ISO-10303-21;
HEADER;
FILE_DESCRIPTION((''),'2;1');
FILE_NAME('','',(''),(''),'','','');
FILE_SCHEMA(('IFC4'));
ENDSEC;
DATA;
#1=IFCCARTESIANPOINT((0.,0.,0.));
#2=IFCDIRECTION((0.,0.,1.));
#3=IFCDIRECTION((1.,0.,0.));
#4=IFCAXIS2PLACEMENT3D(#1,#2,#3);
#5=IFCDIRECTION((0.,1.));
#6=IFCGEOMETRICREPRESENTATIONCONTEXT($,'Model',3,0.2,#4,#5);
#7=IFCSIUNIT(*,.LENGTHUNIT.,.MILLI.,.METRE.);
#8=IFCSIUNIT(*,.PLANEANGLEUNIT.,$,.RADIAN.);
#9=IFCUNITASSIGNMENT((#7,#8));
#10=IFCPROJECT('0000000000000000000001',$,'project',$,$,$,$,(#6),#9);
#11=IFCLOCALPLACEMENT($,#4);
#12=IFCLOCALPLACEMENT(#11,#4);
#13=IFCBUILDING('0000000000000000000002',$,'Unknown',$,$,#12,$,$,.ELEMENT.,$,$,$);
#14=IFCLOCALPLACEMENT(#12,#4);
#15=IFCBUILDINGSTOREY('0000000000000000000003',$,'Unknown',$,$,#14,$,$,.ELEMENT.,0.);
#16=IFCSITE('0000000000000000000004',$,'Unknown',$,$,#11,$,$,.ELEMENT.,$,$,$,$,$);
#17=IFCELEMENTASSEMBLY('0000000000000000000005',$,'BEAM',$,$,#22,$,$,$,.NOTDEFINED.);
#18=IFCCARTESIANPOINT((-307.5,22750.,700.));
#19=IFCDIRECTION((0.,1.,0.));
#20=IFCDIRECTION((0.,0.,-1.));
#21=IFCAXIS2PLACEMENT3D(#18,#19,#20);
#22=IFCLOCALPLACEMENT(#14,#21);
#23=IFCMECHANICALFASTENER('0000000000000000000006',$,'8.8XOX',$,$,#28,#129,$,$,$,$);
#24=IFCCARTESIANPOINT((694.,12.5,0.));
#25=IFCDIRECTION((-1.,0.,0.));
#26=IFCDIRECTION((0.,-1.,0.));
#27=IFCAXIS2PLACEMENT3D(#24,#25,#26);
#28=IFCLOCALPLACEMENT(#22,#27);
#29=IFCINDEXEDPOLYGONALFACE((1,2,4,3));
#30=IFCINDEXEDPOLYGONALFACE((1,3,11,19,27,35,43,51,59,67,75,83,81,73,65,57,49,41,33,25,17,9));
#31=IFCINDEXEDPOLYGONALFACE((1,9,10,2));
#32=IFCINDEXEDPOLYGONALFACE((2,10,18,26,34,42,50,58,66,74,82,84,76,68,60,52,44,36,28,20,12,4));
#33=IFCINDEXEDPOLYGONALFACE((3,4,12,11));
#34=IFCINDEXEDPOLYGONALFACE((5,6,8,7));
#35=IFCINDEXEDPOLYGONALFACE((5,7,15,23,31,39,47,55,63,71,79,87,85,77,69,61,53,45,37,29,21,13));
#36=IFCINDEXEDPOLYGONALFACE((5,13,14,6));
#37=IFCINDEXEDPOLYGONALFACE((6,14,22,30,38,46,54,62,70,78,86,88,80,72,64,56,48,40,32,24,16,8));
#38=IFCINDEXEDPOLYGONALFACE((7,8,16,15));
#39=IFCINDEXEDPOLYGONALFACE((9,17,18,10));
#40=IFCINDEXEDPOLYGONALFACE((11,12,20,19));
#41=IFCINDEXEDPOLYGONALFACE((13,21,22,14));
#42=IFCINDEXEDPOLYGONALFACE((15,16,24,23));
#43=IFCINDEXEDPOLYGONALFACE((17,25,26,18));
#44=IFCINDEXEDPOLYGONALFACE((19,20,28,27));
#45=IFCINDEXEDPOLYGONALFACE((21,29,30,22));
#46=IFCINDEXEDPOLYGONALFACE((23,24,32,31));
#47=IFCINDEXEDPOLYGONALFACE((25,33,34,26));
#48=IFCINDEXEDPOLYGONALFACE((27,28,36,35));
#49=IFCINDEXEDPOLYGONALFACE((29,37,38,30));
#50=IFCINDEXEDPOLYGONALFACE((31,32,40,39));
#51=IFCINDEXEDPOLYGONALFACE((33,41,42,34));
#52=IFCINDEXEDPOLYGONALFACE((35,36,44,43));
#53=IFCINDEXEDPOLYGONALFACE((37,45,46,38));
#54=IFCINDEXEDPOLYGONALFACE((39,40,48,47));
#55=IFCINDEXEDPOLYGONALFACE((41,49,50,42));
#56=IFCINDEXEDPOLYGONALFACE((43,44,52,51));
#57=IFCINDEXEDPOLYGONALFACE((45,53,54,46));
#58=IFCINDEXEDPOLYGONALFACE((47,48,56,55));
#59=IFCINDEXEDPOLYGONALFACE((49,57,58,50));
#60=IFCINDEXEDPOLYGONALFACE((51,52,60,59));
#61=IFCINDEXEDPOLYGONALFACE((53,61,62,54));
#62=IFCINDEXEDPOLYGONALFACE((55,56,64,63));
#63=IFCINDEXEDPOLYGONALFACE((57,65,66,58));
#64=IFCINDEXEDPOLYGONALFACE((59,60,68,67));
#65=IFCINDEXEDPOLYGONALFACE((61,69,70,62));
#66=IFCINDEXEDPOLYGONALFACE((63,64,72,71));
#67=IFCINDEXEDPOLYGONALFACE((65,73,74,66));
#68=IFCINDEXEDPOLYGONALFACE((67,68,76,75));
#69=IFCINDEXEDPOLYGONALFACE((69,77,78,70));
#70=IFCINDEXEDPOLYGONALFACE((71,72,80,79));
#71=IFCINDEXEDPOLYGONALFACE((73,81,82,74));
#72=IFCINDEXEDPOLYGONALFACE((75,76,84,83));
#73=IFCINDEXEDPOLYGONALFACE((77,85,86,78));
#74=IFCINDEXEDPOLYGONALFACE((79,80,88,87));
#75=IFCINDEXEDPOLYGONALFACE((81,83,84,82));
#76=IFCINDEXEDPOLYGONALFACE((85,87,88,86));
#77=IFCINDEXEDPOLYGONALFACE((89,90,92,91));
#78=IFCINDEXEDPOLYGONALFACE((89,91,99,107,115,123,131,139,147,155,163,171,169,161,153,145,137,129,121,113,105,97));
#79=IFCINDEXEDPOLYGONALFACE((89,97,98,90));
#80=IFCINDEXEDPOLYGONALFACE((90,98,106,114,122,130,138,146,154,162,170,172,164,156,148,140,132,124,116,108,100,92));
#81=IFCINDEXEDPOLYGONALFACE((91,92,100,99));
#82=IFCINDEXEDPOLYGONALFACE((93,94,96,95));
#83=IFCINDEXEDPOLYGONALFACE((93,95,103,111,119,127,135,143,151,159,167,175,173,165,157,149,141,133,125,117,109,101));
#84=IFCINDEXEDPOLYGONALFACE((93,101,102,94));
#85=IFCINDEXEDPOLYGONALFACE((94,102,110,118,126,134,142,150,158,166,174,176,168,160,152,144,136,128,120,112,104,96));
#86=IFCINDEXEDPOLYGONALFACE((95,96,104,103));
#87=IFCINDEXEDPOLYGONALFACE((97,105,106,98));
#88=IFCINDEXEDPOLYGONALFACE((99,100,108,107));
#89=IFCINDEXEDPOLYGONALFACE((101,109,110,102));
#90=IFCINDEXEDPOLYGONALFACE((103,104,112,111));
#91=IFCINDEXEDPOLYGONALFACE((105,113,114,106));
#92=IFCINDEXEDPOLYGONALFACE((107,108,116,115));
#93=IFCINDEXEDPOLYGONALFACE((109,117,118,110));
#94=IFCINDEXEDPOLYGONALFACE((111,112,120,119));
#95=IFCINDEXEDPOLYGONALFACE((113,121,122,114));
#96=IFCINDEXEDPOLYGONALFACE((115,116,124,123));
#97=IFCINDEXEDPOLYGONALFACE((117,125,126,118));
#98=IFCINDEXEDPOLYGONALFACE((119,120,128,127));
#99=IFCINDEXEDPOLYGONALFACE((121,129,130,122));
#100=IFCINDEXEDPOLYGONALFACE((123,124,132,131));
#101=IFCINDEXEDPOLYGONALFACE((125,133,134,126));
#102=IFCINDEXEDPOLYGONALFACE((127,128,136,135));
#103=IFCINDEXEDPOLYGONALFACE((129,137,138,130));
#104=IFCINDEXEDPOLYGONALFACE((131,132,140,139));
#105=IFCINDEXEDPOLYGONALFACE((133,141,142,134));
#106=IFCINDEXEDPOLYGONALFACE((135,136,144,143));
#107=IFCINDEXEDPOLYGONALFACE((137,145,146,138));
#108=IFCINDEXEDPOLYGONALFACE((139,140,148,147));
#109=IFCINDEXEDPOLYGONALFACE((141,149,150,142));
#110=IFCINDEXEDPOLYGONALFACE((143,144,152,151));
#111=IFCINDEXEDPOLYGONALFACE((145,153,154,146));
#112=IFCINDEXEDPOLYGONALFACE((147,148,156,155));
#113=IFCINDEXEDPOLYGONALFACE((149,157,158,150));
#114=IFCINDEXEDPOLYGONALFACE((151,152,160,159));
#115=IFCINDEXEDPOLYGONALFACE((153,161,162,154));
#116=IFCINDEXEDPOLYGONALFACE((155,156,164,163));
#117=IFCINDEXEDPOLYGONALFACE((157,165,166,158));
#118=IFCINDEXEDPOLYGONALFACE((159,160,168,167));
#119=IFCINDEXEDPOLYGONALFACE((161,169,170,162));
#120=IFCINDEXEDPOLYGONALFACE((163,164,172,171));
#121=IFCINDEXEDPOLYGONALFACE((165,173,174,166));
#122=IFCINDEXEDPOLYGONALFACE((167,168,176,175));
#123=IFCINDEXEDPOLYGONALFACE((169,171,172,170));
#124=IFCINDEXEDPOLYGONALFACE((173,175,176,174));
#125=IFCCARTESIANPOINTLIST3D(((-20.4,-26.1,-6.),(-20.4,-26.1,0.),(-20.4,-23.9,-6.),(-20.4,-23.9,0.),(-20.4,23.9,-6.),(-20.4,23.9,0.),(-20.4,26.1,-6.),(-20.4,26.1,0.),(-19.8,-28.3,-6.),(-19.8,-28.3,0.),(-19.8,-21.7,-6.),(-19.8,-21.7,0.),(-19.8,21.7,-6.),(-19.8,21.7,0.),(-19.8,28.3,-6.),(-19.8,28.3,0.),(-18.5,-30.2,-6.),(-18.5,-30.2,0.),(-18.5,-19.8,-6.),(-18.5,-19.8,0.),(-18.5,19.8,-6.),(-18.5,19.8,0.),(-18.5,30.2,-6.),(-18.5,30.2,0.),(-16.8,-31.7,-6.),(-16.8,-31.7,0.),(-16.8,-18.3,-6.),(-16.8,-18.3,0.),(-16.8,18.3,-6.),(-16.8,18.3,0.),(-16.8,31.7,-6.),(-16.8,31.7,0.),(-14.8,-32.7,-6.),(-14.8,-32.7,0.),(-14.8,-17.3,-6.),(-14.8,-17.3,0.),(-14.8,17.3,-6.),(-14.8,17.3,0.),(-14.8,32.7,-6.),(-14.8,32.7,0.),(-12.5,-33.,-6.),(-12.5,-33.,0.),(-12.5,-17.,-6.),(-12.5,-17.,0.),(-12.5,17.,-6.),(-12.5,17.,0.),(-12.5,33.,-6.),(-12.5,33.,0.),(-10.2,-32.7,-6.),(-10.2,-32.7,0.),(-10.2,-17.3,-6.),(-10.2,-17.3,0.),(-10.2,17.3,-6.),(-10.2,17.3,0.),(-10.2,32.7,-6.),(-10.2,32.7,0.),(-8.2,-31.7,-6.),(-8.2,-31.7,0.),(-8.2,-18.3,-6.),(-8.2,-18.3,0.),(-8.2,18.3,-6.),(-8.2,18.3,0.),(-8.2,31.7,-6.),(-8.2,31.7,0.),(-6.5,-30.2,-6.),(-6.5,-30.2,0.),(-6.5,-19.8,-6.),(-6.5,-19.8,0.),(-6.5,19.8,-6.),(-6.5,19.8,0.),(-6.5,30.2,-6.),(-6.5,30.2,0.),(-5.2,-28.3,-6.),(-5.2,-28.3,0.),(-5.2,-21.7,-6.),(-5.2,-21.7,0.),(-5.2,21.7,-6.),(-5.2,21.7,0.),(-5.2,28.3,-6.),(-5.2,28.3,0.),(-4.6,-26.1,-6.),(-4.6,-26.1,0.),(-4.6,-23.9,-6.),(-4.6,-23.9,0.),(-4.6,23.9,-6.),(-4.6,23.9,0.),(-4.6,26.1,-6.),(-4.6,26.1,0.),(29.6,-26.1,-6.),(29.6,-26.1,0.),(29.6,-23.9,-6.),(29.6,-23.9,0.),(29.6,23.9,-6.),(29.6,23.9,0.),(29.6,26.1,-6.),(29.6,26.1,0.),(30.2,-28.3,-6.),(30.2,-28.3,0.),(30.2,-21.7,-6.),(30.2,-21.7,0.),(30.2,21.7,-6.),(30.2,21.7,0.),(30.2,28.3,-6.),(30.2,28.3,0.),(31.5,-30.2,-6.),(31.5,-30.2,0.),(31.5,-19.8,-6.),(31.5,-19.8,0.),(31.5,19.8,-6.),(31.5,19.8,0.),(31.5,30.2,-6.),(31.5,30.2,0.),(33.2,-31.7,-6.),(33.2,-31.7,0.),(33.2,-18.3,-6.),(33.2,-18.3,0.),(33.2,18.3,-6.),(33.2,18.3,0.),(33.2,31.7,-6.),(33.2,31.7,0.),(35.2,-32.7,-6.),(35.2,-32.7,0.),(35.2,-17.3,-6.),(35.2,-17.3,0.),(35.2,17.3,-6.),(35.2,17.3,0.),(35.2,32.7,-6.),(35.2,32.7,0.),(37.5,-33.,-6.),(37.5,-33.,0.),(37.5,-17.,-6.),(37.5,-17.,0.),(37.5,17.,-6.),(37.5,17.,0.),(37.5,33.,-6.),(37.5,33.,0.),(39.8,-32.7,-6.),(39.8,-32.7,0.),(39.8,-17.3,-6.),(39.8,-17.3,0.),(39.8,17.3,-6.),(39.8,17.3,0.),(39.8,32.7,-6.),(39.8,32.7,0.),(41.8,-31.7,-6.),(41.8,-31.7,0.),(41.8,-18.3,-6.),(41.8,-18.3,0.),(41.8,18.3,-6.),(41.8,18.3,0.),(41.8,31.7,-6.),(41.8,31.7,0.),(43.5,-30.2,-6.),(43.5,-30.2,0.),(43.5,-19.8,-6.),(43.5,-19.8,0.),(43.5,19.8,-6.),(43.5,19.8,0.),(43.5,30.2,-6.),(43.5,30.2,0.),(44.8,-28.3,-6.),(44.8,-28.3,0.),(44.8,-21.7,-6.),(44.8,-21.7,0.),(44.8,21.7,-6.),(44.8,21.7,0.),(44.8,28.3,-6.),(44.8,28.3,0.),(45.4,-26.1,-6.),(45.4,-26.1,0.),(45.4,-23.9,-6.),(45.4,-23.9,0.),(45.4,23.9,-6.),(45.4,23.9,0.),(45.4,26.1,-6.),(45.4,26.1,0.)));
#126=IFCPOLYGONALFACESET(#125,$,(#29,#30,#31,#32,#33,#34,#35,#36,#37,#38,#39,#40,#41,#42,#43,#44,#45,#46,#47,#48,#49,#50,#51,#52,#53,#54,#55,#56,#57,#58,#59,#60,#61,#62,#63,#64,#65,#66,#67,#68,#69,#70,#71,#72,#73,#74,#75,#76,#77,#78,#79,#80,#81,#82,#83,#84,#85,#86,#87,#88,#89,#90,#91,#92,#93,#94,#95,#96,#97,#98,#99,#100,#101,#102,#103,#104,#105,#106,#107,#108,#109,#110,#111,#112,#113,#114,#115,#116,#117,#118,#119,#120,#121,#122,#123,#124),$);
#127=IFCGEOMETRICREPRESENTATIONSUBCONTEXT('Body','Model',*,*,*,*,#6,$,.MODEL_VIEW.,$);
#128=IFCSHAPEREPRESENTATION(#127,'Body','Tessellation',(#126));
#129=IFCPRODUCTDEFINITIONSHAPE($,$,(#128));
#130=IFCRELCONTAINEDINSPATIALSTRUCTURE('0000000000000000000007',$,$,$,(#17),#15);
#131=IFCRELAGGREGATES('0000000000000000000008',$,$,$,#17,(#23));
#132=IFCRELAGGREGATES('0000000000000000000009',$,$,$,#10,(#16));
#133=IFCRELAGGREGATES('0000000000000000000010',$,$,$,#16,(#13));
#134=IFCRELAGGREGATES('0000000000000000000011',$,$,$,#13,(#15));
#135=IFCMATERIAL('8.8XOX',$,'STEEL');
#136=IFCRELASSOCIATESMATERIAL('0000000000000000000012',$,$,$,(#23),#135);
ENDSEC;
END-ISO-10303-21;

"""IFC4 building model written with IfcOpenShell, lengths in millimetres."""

from ifc_helpers import new_model, si_unit, direction, frame, origin_with_axes, place, context, subcontext, project, spatial, arc, indexed_curve, outline, extrude, source, transform, mapped, material, element, aggregate, save


model = new_model("IFC4")

# Units and contexts
model_context = context("Model", 3, precision=0.2, world=origin_with_axes(), true_north=direction((0.0, 1.0)))
body_context = subcontext(model_context, "Body", "Model", "MODEL_VIEW")
ifc_project = project(units=[si_unit("LENGTHUNIT", "METRE", prefix="MILLI"), si_unit("PLANEANGLEUNIT", "RADIAN")], contexts=[model_context])

# Site, building, storey
site_placement = place(None, origin_with_axes())
site = spatial("IfcSite", under=ifc_project, at=site_placement, Name="Unknown", CompositionType="ELEMENT")
building_placement = place(site_placement, origin_with_axes())
building = spatial("IfcBuilding", under=site, at=building_placement, Name="Unknown", CompositionType="ELEMENT")
storey_placement = place(building_placement, origin_with_axes())
storey = spatial("IfcBuildingStorey", under=building, at=storey_placement, Name="Unknown", CompositionType="ELEMENT", Elevation=0.0)

# Element assembly
assembly_1_placement = place(storey_placement, frame((-307.5, 22750.0, 700.0), z_axis=(0.0, 1.0, 0.0), x_axis=(0.0, 0.0, -1.0)))
assembly_1 = element("IfcElementAssembly", 1, at=assembly_1_placement, inside=storey, Name="BEAM", PredefinedType="NOTDEFINED")

# Shared definitions
ifc_material_1 = material(Name="8.8XOX", Category="STEEL")

# Mechanical fastener
shared_shape_1 = source(origin_with_axes(), body_context, "Body", "SweptSolid", [
    extrude(outline(indexed_curve([(8.0, 0.0), (0.0, 8.0), (-8.0, 0.0), (0.0, -8.0)], segments=[arc(1, 2, 3), arc(3, 4, 1)])), frame((0.0, 0.0, 0.0), z_axis=(0.0, 0.0, -1.0), x_axis=(0.0, 1.0, 0.0)), (0.0, 0.0, 1.0), 6.0),
])
mechanical_fastener_1_placement = place(assembly_1_placement, frame((694.0, 12.5, 0.0), z_axis=(-1.0, 0.0, 0.0), x_axis=(0.0, -1.0, 0.0)))
mechanical_fastener_1 = element("IfcMechanicalFastener", 2, at=mechanical_fastener_1_placement, material=ifc_material_1, Name="8.8XOX", context=body_context, shape_type="MappedRepresentation", body=[
    mapped(shared_shape_1, transform((-12.5, 25.0, 0.0))),
    mapped(shared_shape_1, transform((-12.5, -25.0, 0.0))),
    mapped(shared_shape_1, transform((37.5, 25.0, 0.0))),
    mapped(shared_shape_1, transform((37.5, -25.0, 0.0))),
])
aggregate(assembly_1, [mechanical_fastener_1])

save(model, "model.ifc")
